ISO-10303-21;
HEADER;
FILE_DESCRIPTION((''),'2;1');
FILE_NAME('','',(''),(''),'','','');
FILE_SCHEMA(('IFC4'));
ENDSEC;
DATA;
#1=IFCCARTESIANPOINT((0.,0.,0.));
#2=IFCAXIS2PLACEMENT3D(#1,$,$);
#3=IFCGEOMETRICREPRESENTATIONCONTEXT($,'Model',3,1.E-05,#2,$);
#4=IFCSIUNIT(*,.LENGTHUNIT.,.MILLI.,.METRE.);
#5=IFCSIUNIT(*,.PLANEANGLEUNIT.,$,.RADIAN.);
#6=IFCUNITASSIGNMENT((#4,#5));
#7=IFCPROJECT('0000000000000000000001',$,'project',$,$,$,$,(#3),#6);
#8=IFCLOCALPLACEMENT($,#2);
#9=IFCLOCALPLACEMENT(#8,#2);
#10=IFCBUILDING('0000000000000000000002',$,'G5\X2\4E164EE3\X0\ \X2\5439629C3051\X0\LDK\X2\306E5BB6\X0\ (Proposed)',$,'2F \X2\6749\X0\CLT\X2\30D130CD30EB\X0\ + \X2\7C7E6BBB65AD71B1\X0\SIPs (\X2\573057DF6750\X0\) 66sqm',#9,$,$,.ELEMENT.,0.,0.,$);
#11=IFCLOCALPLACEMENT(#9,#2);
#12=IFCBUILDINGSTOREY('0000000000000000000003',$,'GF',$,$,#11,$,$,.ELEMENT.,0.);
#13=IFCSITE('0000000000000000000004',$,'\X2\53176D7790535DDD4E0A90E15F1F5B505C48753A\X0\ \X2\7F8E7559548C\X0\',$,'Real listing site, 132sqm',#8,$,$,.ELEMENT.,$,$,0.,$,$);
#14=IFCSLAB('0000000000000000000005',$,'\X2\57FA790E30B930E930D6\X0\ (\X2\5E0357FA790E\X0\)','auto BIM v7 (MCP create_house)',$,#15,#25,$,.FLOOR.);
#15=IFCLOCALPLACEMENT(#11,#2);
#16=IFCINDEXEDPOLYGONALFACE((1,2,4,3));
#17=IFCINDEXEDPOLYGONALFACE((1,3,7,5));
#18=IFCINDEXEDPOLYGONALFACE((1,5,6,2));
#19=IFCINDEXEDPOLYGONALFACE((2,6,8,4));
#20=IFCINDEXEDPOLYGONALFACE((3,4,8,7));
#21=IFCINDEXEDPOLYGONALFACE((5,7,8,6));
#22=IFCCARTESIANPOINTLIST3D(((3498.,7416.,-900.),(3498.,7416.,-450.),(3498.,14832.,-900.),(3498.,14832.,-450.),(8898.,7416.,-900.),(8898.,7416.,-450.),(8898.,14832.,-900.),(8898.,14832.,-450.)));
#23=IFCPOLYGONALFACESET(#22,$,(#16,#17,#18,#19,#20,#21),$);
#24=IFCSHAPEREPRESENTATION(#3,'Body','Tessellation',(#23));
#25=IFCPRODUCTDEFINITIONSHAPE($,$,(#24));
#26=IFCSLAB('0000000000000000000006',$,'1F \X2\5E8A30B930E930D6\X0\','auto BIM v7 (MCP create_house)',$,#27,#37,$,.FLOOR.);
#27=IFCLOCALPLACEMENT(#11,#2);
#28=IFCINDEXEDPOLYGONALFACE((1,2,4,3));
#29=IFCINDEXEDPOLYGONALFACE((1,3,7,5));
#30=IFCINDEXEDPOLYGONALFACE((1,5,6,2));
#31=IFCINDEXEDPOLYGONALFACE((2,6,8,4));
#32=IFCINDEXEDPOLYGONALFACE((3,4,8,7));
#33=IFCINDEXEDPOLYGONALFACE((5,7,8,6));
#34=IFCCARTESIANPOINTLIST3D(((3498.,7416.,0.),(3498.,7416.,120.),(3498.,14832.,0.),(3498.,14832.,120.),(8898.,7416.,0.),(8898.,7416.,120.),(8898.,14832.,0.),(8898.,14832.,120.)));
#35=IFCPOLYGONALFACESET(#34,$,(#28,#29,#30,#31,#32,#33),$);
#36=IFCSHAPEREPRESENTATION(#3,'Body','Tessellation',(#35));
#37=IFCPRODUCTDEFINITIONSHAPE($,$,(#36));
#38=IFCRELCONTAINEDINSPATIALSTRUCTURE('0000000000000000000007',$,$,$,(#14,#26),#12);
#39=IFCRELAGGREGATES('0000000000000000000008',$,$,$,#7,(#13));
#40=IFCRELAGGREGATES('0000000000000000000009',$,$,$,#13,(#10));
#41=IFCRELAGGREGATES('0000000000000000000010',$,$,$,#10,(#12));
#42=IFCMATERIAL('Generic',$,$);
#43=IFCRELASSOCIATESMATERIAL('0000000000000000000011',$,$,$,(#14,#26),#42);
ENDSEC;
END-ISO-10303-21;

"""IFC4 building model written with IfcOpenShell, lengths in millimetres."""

from ifc_helpers import new_model, si_unit, frame, frame_2d, origin, place, context, project, spatial, rectangle, extrude, material, element, save


model = new_model("IFC4")

# Units and contexts
model_context = context("Model", 3, precision=1e-05, world=origin())
ifc_project = project(units=[si_unit("LENGTHUNIT", "METRE", prefix="MILLI"), si_unit("PLANEANGLEUNIT", "RADIAN")], contexts=[model_context])

# Site, building, storey
site_placement = place(None, origin())
site = spatial("IfcSite", under=ifc_project, at=site_placement, Name="北海道川上郡弟子屈町 美留和", ObjectType="Real listing site, 132sqm", CompositionType="ELEMENT", RefElevation=0.0)
building_placement = place(site_placement, origin())
building = spatial("IfcBuilding", under=site, at=building_placement, Name="G5世代 吹抜けLDKの家 (Proposed)", ObjectType="2F 杉CLTパネル + 籾殻断熱SIPs (地域材) 66sqm", CompositionType="ELEMENT", ElevationOfRefHeight=0.0, ElevationOfTerrain=0.0)
storey_placement = place(building_placement, origin())
storey = spatial("IfcBuildingStorey", under=building, at=storey_placement, Name="GF", CompositionType="ELEMENT", Elevation=0.0)

# Slabs
ifc_material = material(Name="Generic")
slab_1_placement = place(storey_placement, frame((1749.0, 3708.0, -450.0)))
element("IfcSlab", 1, at=slab_1_placement, inside=storey, material=ifc_material, Name="基礎スラブ (布基礎)", Description="auto BIM v7 (MCP create_house)", PredefinedType="FLOOR", context=model_context, shape_type="SweptSolid", body=[
    extrude(rectangle(XDim=5400.0, YDim=7416.0, at=frame_2d((2700.0, 3708.0))), frame((1749.0, 3708.0, -450.0)), (0.0, 0.0, 1.0), 450.0),
])
slab_2_placement = place(storey_placement, frame((1749.0, 3708.0, 0.0)))
element("IfcSlab", 2, at=slab_2_placement, inside=storey, material=ifc_material, Name="1F 床スラブ", Description="auto BIM v7 (MCP create_house)", PredefinedType="FLOOR", context=model_context, shape_type="SweptSolid", body=[
    extrude(rectangle(XDim=5400.0, YDim=7416.0, at=frame_2d((2700.0, 3708.0))), frame((1749.0, 3708.0, 0.0)), (0.0, 0.0, 1.0), 120.0),
])

save(model, "model.ifc")
